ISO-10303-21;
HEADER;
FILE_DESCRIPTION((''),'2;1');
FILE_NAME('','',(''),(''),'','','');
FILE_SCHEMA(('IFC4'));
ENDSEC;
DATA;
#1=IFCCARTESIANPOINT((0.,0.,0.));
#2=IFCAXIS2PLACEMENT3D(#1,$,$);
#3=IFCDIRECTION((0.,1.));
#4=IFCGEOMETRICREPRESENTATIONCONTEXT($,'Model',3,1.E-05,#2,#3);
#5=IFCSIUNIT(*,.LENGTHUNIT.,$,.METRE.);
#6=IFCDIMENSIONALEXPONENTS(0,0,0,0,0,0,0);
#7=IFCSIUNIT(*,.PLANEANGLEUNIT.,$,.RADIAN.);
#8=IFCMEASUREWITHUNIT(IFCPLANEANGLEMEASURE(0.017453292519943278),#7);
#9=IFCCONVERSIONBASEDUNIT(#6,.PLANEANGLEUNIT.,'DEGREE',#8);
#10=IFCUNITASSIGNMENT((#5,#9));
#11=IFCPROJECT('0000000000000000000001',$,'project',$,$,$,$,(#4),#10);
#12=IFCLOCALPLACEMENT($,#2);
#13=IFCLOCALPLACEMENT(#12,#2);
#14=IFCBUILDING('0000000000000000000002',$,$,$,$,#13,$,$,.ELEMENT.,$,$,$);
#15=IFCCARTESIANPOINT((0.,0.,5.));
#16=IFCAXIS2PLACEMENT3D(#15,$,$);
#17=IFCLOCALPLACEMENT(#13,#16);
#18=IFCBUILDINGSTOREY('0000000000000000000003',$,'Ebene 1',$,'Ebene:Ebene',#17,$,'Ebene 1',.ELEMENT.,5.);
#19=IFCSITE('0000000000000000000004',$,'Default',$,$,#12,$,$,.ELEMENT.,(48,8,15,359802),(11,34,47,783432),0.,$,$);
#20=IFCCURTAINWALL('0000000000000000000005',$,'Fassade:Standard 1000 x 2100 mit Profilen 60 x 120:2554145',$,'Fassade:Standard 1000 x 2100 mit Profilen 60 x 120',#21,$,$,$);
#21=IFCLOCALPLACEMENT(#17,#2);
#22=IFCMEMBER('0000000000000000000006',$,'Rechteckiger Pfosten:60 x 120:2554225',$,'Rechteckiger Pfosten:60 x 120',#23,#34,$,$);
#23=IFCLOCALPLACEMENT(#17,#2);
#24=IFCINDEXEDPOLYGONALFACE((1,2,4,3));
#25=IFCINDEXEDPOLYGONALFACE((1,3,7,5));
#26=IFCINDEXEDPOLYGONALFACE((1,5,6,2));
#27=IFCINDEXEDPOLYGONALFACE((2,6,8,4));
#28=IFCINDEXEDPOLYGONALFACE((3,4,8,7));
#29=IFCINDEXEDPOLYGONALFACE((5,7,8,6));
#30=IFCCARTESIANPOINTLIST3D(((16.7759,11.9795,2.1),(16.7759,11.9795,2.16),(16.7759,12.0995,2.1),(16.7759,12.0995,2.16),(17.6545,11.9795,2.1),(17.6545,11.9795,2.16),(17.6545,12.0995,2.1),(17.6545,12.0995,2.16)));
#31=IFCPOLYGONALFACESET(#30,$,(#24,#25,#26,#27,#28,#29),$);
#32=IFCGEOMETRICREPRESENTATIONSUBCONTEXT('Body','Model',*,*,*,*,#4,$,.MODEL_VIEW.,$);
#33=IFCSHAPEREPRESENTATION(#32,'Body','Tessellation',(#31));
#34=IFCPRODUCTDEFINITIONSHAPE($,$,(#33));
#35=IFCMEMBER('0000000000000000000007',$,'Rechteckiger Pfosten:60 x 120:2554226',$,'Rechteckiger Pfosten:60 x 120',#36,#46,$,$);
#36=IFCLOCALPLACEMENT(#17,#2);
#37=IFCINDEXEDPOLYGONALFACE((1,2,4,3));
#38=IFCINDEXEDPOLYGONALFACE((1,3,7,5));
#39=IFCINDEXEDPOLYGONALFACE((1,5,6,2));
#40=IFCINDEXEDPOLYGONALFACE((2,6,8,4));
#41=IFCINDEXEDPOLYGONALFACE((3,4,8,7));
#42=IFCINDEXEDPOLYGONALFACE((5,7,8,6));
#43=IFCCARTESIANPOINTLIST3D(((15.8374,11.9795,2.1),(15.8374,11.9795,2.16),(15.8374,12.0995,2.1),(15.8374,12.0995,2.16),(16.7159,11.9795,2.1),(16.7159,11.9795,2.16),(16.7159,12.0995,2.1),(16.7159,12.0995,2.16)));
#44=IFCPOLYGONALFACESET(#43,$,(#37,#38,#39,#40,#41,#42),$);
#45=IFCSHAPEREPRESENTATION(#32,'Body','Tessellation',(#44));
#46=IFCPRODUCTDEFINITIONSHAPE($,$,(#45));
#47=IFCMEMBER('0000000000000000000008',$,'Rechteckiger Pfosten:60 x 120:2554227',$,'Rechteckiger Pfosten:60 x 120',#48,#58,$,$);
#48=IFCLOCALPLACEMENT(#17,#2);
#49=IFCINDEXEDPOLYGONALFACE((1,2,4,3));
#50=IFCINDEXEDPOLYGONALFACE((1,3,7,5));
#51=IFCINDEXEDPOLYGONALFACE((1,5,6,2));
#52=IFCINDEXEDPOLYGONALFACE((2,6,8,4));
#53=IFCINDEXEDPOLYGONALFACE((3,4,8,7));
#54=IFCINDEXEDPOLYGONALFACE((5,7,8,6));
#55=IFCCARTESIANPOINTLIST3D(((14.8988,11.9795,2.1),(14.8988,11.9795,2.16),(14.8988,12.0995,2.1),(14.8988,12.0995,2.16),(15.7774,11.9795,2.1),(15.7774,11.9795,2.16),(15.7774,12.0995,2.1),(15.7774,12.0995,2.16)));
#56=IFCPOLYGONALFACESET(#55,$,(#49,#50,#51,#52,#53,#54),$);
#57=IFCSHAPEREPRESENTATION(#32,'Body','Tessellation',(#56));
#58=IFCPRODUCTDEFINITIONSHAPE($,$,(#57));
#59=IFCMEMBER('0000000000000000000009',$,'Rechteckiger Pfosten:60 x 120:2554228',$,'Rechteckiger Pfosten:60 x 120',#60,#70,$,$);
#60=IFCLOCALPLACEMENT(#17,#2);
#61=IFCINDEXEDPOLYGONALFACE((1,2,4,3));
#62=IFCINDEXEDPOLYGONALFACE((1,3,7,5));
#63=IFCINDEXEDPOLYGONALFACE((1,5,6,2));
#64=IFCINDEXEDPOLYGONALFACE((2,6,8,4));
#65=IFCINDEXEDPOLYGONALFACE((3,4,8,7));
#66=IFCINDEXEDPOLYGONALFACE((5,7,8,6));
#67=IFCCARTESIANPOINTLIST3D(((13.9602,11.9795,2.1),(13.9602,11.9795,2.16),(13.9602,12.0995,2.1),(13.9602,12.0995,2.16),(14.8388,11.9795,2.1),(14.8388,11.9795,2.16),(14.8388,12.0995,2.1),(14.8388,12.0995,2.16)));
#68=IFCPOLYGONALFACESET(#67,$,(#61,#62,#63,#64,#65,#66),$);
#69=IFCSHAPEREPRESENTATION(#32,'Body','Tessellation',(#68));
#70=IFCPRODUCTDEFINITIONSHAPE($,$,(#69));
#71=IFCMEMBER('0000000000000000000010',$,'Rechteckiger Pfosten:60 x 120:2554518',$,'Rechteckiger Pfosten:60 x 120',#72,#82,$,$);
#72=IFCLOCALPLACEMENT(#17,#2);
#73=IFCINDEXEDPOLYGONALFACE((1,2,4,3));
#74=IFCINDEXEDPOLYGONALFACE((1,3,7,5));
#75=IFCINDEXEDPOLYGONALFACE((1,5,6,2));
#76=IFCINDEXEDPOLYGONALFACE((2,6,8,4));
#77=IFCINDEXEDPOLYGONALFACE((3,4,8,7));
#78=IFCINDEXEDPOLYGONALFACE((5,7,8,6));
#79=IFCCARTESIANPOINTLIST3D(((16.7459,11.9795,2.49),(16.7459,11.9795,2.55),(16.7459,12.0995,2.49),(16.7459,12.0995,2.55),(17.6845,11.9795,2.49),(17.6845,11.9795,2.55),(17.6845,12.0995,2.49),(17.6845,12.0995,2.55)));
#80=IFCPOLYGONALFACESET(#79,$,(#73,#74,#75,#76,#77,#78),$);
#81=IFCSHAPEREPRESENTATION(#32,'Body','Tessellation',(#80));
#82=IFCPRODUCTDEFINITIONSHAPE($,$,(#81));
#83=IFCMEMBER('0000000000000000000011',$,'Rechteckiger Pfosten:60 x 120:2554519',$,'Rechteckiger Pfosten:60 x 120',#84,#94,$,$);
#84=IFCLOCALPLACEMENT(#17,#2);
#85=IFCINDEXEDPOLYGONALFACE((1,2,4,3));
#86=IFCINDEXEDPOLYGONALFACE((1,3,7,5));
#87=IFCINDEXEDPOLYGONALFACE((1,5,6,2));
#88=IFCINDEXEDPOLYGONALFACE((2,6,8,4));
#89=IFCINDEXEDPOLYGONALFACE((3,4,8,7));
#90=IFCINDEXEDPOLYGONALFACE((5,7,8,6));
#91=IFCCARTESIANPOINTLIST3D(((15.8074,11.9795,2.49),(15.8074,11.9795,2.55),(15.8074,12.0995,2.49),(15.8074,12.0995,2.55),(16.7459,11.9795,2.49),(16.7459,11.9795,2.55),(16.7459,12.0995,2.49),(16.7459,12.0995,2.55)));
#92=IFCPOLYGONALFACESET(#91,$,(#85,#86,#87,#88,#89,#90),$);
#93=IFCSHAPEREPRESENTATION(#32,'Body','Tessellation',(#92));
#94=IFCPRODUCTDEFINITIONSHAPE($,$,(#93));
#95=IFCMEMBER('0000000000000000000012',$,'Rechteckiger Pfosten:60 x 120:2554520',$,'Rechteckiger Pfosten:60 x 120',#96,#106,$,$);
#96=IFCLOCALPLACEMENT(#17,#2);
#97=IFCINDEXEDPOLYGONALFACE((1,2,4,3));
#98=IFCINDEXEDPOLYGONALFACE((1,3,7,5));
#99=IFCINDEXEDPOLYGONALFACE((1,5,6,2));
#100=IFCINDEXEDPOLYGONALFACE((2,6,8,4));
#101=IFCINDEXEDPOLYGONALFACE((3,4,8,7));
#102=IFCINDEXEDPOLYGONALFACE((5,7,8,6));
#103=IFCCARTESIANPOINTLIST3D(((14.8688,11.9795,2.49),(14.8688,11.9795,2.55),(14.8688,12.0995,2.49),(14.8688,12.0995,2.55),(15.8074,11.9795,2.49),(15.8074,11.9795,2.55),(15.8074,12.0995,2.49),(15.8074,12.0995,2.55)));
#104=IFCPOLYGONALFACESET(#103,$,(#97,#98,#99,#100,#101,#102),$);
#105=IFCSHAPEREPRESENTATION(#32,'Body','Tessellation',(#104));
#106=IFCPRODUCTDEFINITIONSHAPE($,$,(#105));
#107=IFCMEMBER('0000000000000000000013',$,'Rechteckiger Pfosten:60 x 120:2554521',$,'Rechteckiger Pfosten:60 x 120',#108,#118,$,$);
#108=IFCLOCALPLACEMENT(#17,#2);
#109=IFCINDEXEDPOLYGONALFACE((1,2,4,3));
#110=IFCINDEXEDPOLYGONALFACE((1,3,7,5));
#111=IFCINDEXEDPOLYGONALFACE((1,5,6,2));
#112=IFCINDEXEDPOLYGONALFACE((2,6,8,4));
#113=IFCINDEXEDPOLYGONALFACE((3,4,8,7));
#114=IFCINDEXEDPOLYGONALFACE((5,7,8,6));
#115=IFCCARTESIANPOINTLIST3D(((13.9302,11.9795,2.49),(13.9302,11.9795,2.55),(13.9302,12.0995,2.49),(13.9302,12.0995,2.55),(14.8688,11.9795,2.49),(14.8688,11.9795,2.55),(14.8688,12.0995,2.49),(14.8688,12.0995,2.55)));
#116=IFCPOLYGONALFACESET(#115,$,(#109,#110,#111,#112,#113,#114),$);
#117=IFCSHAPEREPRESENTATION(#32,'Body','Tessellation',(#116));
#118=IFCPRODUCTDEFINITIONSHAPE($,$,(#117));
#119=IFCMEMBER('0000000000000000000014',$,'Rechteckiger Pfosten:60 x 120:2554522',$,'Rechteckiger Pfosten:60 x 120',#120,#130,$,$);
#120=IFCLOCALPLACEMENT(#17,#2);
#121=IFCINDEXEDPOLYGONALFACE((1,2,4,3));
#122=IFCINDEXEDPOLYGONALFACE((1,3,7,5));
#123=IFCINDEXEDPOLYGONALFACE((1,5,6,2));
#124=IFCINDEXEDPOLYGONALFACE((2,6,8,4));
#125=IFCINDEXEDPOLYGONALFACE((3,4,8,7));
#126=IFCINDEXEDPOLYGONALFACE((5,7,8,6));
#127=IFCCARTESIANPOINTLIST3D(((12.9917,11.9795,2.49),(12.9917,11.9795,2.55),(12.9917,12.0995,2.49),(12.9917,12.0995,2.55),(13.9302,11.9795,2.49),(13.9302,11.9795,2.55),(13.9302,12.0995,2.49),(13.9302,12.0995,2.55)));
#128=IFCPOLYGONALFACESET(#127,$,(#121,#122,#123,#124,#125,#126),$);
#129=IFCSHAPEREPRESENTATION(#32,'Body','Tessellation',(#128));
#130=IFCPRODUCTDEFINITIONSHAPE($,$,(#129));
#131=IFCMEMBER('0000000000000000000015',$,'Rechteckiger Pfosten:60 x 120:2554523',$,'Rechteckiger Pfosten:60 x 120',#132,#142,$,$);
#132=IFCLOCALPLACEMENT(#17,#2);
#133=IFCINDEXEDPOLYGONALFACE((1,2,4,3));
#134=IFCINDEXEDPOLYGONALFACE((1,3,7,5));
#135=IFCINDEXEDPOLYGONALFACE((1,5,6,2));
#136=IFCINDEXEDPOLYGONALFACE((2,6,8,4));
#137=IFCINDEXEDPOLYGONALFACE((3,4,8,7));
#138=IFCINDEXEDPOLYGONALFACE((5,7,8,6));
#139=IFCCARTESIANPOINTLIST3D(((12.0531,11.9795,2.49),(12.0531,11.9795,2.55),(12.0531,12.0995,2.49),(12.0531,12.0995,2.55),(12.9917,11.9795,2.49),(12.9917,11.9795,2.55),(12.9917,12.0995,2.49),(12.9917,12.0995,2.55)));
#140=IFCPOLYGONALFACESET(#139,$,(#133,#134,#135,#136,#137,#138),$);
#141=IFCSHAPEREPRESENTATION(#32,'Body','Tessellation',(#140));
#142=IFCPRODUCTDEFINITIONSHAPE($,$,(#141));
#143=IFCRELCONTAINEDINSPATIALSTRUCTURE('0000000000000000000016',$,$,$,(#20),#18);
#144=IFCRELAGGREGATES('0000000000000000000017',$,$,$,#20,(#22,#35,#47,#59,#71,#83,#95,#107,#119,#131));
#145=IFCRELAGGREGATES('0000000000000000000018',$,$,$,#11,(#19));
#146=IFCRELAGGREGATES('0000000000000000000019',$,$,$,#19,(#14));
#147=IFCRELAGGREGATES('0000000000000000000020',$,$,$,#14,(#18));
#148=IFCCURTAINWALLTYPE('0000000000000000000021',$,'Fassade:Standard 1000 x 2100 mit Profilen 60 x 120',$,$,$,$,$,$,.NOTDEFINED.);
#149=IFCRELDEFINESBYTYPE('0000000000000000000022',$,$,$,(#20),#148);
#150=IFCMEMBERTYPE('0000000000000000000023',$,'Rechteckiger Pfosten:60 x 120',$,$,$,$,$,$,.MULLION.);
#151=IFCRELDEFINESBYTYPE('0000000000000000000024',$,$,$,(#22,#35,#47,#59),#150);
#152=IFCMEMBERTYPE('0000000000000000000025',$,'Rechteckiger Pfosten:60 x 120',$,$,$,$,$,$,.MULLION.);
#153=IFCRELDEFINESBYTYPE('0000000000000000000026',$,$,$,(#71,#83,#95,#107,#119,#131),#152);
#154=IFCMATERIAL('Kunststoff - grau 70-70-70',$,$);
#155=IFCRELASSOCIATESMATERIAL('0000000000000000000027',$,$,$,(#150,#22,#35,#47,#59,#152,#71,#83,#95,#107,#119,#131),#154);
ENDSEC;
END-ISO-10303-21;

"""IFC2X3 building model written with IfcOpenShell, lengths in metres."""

from ifc_helpers import new_model, entity, si_unit, converted_unit, direction, frame, frame_2d, origin, origin_2d_with_axis, place, context, subcontext, project, spatial, rectangle, extrude, source, transform, mapped, material, type_object, type_shapes, element, aggregate, save


model = new_model("IFC2X3")

# Units and contexts
model_context = context("Model", 3, precision=1e-05, world=origin(), true_north=direction((0.0, 1.0)))
body_context = subcontext(model_context, "Body", "Model", "MODEL_VIEW")
ifc_project = project(units=[si_unit("LENGTHUNIT", "METRE"), converted_unit("PLANEANGLEUNIT", "DEGREE", entity("IfcPlaneAngleMeasure", 0.017453292519943278), si_unit("PLANEANGLEUNIT", "RADIAN"), dimensions=[0, 0, 0, 0, 0, 0, 0])], contexts=[model_context])

# Site, building, storey
site_placement = place(None, origin())
site = spatial("IfcSite", under=ifc_project, at=site_placement, Name="Default", CompositionType="ELEMENT", RefLatitude=(48, 8, 15, 359802), RefLongitude=(11, 34, 47, 783432), RefElevation=0.0)
building_placement = place(site_placement, origin())
building = spatial("IfcBuilding", under=site, at=building_placement, CompositionType="ELEMENT")
storey_placement = place(building_placement, frame((0.0, 0.0, 5.0)))
storey = spatial("IfcBuildingStorey", under=building, at=storey_placement, Name="Ebene 1", ObjectType="Ebene:Ebene", LongName="Ebene 1", CompositionType="ELEMENT", Elevation=5.0)

# Shared definitions
curtain_wall_type = type_object("IfcCurtainWallType", Name="Fassade:Standard 1000 x 2100 mit Profilen 60 x 120", PredefinedType="NOTDEFINED")
ifc_material_1 = material(Name="Kunststoff - grau 70-70-70")

# Curtain wall
curtain_wall_1_placement = place(storey_placement, frame((0.0, 0.0, -5.0)))
curtain_wall_1 = element("IfcCurtainWall", 1, at=curtain_wall_1_placement, inside=storey, type_object=curtain_wall_type, Name="Fassade:Standard 1000 x 2100 mit Profilen 60 x 120:2554145", ObjectType="Fassade:Standard 1000 x 2100 mit Profilen 60 x 120")

# Members
member_type_1 = type_object("IfcMemberType", Name="Rechteckiger Pfosten:60 x 120", PredefinedType="MULLION", material=ifc_material_1)
shared_shape_1 = source(origin(), body_context, "Body", "SweptSolid", [
    extrude(rectangle(XDim=0.06, YDim=0.12, at=frame_2d((0.0, 0.0), x_axis=(1.0, 0.0))), frame((0.0, 0.0, -0.8786), z_axis=(0.0, 0.0, 1.0), x_axis=(-1.0, 0.0, 0.0)), (0.0, 0.0, 1.0), 0.8786),
])
type_shapes(member_type_1, [shared_shape_1])
member_1_placement = place(curtain_wall_1_placement, frame((16.7759, 12.0395, 7.13), z_axis=(-1.0, 0.0, 0.0), x_axis=(0.0, 0.0, 1.0)))
member_1 = element("IfcMember", 2, at=member_1_placement, type_object=member_type_1, material=ifc_material_1, Name="Rechteckiger Pfosten:60 x 120:2554225", ObjectType="Rechteckiger Pfosten:60 x 120", context=body_context, shape_type="MappedRepresentation", body=[
    mapped(shared_shape_1, transform((0.0, 0.0, 0.0), scale=1.0)),
])
member_2_placement = place(curtain_wall_1_placement, frame((15.8374, 12.0395, 7.13), z_axis=(-1.0, 0.0, 0.0), x_axis=(0.0, 0.0, 1.0)))
member_2 = element("IfcMember", 3, at=member_2_placement, type_object=member_type_1, material=ifc_material_1, Name="Rechteckiger Pfosten:60 x 120:2554226", ObjectType="Rechteckiger Pfosten:60 x 120", context=body_context, shape_type="MappedRepresentation", body=[
    mapped(shared_shape_1, transform((0.0, 0.0, 0.0), scale=1.0)),
])
member_3_placement = place(curtain_wall_1_placement, frame((14.8988, 12.0395, 7.13), z_axis=(-1.0, 0.0, 0.0), x_axis=(0.0, 0.0, 1.0)))
member_3 = element("IfcMember", 4, at=member_3_placement, type_object=member_type_1, material=ifc_material_1, Name="Rechteckiger Pfosten:60 x 120:2554227", ObjectType="Rechteckiger Pfosten:60 x 120", context=body_context, shape_type="MappedRepresentation", body=[
    mapped(shared_shape_1, transform((0.0, 0.0, 0.0), scale=1.0)),
])
member_4_placement = place(curtain_wall_1_placement, frame((13.9602, 12.0395, 7.13), z_axis=(-1.0, 0.0, 0.0), x_axis=(0.0, 0.0, 1.0)))
member_4 = element("IfcMember", 5, at=member_4_placement, type_object=member_type_1, material=ifc_material_1, Name="Rechteckiger Pfosten:60 x 120:2554228", ObjectType="Rechteckiger Pfosten:60 x 120", context=body_context, shape_type="MappedRepresentation", body=[
    mapped(shared_shape_1, transform((0.0, 0.0, 0.0), scale=1.0)),
])
member_type_2 = type_object("IfcMemberType", Name="Rechteckiger Pfosten:60 x 120", PredefinedType="MULLION", material=ifc_material_1)
shared_shape_2 = source(origin(), body_context, "Body", "SweptSolid", [
    extrude(rectangle(XDim=0.06, YDim=0.12, at=origin_2d_with_axis()), frame((-0.03, 0.0, -0.9386), z_axis=(0.0, 0.0, 1.0), x_axis=(-1.0, 0.0, 0.0)), (0.0, 0.0, 1.0), 0.9386),
])
type_shapes(member_type_2, [shared_shape_2])
member_5_placement = place(curtain_wall_1_placement, frame((16.7459, 12.0395, 7.55), z_axis=(-1.0, 0.0, 0.0), x_axis=(0.0, 0.0, 1.0)))
member_5 = element("IfcMember", 6, at=member_5_placement, type_object=member_type_2, material=ifc_material_1, Name="Rechteckiger Pfosten:60 x 120:2554518", ObjectType="Rechteckiger Pfosten:60 x 120", context=body_context, shape_type="MappedRepresentation", body=[
    mapped(shared_shape_2, transform((0.0, 0.0, 0.0), scale=1.0)),
])
member_6_placement = place(curtain_wall_1_placement, frame((15.8074, 12.0395, 7.55), z_axis=(-1.0, 0.0, 0.0), x_axis=(0.0, 0.0, 1.0)))
member_6 = element("IfcMember", 7, at=member_6_placement, type_object=member_type_2, material=ifc_material_1, Name="Rechteckiger Pfosten:60 x 120:2554519", ObjectType="Rechteckiger Pfosten:60 x 120", context=body_context, shape_type="MappedRepresentation", body=[
    mapped(shared_shape_2, transform((0.0, 0.0, 0.0), scale=1.0)),
])
member_7_placement = place(curtain_wall_1_placement, frame((14.8688, 12.0395, 7.55), z_axis=(-1.0, 0.0, 0.0), x_axis=(0.0, 0.0, 1.0)))
member_7 = element("IfcMember", 8, at=member_7_placement, type_object=member_type_2, material=ifc_material_1, Name="Rechteckiger Pfosten:60 x 120:2554520", ObjectType="Rechteckiger Pfosten:60 x 120", context=body_context, shape_type="MappedRepresentation", body=[
    mapped(shared_shape_2, transform((0.0, 0.0, 0.0), scale=1.0)),
])
member_8_placement = place(curtain_wall_1_placement, frame((13.9302, 12.0395, 7.55), z_axis=(-1.0, 0.0, 0.0), x_axis=(0.0, 0.0, 1.0)))
member_8 = element("IfcMember", 9, at=member_8_placement, type_object=member_type_2, material=ifc_material_1, Name="Rechteckiger Pfosten:60 x 120:2554521", ObjectType="Rechteckiger Pfosten:60 x 120", context=body_context, shape_type="MappedRepresentation", body=[
    mapped(shared_shape_2, transform((0.0, 0.0, 0.0), scale=1.0)),
])
member_9_placement = place(curtain_wall_1_placement, frame((12.9917, 12.0395, 7.55), z_axis=(-1.0, 0.0, 0.0), x_axis=(0.0, 0.0, 1.0)))
member_9 = element("IfcMember", 10, at=member_9_placement, type_object=member_type_2, material=ifc_material_1, Name="Rechteckiger Pfosten:60 x 120:2554522", ObjectType="Rechteckiger Pfosten:60 x 120", context=body_context, shape_type="MappedRepresentation", body=[
    mapped(shared_shape_2, transform((0.0, 0.0, 0.0), scale=1.0)),
])
member_10_placement = place(curtain_wall_1_placement, frame((12.0531, 12.0395, 7.55), z_axis=(-1.0, 0.0, 0.0), x_axis=(0.0, 0.0, 1.0)))
member_10 = element("IfcMember", 11, at=member_10_placement, type_object=member_type_2, material=ifc_material_1, Name="Rechteckiger Pfosten:60 x 120:2554523", ObjectType="Rechteckiger Pfosten:60 x 120", context=body_context, shape_type="MappedRepresentation", body=[
    mapped(shared_shape_2, transform((0.0, 0.0, 0.0), scale=1.0)),
])

aggregate(curtain_wall_1, [member_1, member_2, member_3, member_4, member_5, member_6, member_7, member_8, member_9, member_10])

save(model, "model.ifc")
